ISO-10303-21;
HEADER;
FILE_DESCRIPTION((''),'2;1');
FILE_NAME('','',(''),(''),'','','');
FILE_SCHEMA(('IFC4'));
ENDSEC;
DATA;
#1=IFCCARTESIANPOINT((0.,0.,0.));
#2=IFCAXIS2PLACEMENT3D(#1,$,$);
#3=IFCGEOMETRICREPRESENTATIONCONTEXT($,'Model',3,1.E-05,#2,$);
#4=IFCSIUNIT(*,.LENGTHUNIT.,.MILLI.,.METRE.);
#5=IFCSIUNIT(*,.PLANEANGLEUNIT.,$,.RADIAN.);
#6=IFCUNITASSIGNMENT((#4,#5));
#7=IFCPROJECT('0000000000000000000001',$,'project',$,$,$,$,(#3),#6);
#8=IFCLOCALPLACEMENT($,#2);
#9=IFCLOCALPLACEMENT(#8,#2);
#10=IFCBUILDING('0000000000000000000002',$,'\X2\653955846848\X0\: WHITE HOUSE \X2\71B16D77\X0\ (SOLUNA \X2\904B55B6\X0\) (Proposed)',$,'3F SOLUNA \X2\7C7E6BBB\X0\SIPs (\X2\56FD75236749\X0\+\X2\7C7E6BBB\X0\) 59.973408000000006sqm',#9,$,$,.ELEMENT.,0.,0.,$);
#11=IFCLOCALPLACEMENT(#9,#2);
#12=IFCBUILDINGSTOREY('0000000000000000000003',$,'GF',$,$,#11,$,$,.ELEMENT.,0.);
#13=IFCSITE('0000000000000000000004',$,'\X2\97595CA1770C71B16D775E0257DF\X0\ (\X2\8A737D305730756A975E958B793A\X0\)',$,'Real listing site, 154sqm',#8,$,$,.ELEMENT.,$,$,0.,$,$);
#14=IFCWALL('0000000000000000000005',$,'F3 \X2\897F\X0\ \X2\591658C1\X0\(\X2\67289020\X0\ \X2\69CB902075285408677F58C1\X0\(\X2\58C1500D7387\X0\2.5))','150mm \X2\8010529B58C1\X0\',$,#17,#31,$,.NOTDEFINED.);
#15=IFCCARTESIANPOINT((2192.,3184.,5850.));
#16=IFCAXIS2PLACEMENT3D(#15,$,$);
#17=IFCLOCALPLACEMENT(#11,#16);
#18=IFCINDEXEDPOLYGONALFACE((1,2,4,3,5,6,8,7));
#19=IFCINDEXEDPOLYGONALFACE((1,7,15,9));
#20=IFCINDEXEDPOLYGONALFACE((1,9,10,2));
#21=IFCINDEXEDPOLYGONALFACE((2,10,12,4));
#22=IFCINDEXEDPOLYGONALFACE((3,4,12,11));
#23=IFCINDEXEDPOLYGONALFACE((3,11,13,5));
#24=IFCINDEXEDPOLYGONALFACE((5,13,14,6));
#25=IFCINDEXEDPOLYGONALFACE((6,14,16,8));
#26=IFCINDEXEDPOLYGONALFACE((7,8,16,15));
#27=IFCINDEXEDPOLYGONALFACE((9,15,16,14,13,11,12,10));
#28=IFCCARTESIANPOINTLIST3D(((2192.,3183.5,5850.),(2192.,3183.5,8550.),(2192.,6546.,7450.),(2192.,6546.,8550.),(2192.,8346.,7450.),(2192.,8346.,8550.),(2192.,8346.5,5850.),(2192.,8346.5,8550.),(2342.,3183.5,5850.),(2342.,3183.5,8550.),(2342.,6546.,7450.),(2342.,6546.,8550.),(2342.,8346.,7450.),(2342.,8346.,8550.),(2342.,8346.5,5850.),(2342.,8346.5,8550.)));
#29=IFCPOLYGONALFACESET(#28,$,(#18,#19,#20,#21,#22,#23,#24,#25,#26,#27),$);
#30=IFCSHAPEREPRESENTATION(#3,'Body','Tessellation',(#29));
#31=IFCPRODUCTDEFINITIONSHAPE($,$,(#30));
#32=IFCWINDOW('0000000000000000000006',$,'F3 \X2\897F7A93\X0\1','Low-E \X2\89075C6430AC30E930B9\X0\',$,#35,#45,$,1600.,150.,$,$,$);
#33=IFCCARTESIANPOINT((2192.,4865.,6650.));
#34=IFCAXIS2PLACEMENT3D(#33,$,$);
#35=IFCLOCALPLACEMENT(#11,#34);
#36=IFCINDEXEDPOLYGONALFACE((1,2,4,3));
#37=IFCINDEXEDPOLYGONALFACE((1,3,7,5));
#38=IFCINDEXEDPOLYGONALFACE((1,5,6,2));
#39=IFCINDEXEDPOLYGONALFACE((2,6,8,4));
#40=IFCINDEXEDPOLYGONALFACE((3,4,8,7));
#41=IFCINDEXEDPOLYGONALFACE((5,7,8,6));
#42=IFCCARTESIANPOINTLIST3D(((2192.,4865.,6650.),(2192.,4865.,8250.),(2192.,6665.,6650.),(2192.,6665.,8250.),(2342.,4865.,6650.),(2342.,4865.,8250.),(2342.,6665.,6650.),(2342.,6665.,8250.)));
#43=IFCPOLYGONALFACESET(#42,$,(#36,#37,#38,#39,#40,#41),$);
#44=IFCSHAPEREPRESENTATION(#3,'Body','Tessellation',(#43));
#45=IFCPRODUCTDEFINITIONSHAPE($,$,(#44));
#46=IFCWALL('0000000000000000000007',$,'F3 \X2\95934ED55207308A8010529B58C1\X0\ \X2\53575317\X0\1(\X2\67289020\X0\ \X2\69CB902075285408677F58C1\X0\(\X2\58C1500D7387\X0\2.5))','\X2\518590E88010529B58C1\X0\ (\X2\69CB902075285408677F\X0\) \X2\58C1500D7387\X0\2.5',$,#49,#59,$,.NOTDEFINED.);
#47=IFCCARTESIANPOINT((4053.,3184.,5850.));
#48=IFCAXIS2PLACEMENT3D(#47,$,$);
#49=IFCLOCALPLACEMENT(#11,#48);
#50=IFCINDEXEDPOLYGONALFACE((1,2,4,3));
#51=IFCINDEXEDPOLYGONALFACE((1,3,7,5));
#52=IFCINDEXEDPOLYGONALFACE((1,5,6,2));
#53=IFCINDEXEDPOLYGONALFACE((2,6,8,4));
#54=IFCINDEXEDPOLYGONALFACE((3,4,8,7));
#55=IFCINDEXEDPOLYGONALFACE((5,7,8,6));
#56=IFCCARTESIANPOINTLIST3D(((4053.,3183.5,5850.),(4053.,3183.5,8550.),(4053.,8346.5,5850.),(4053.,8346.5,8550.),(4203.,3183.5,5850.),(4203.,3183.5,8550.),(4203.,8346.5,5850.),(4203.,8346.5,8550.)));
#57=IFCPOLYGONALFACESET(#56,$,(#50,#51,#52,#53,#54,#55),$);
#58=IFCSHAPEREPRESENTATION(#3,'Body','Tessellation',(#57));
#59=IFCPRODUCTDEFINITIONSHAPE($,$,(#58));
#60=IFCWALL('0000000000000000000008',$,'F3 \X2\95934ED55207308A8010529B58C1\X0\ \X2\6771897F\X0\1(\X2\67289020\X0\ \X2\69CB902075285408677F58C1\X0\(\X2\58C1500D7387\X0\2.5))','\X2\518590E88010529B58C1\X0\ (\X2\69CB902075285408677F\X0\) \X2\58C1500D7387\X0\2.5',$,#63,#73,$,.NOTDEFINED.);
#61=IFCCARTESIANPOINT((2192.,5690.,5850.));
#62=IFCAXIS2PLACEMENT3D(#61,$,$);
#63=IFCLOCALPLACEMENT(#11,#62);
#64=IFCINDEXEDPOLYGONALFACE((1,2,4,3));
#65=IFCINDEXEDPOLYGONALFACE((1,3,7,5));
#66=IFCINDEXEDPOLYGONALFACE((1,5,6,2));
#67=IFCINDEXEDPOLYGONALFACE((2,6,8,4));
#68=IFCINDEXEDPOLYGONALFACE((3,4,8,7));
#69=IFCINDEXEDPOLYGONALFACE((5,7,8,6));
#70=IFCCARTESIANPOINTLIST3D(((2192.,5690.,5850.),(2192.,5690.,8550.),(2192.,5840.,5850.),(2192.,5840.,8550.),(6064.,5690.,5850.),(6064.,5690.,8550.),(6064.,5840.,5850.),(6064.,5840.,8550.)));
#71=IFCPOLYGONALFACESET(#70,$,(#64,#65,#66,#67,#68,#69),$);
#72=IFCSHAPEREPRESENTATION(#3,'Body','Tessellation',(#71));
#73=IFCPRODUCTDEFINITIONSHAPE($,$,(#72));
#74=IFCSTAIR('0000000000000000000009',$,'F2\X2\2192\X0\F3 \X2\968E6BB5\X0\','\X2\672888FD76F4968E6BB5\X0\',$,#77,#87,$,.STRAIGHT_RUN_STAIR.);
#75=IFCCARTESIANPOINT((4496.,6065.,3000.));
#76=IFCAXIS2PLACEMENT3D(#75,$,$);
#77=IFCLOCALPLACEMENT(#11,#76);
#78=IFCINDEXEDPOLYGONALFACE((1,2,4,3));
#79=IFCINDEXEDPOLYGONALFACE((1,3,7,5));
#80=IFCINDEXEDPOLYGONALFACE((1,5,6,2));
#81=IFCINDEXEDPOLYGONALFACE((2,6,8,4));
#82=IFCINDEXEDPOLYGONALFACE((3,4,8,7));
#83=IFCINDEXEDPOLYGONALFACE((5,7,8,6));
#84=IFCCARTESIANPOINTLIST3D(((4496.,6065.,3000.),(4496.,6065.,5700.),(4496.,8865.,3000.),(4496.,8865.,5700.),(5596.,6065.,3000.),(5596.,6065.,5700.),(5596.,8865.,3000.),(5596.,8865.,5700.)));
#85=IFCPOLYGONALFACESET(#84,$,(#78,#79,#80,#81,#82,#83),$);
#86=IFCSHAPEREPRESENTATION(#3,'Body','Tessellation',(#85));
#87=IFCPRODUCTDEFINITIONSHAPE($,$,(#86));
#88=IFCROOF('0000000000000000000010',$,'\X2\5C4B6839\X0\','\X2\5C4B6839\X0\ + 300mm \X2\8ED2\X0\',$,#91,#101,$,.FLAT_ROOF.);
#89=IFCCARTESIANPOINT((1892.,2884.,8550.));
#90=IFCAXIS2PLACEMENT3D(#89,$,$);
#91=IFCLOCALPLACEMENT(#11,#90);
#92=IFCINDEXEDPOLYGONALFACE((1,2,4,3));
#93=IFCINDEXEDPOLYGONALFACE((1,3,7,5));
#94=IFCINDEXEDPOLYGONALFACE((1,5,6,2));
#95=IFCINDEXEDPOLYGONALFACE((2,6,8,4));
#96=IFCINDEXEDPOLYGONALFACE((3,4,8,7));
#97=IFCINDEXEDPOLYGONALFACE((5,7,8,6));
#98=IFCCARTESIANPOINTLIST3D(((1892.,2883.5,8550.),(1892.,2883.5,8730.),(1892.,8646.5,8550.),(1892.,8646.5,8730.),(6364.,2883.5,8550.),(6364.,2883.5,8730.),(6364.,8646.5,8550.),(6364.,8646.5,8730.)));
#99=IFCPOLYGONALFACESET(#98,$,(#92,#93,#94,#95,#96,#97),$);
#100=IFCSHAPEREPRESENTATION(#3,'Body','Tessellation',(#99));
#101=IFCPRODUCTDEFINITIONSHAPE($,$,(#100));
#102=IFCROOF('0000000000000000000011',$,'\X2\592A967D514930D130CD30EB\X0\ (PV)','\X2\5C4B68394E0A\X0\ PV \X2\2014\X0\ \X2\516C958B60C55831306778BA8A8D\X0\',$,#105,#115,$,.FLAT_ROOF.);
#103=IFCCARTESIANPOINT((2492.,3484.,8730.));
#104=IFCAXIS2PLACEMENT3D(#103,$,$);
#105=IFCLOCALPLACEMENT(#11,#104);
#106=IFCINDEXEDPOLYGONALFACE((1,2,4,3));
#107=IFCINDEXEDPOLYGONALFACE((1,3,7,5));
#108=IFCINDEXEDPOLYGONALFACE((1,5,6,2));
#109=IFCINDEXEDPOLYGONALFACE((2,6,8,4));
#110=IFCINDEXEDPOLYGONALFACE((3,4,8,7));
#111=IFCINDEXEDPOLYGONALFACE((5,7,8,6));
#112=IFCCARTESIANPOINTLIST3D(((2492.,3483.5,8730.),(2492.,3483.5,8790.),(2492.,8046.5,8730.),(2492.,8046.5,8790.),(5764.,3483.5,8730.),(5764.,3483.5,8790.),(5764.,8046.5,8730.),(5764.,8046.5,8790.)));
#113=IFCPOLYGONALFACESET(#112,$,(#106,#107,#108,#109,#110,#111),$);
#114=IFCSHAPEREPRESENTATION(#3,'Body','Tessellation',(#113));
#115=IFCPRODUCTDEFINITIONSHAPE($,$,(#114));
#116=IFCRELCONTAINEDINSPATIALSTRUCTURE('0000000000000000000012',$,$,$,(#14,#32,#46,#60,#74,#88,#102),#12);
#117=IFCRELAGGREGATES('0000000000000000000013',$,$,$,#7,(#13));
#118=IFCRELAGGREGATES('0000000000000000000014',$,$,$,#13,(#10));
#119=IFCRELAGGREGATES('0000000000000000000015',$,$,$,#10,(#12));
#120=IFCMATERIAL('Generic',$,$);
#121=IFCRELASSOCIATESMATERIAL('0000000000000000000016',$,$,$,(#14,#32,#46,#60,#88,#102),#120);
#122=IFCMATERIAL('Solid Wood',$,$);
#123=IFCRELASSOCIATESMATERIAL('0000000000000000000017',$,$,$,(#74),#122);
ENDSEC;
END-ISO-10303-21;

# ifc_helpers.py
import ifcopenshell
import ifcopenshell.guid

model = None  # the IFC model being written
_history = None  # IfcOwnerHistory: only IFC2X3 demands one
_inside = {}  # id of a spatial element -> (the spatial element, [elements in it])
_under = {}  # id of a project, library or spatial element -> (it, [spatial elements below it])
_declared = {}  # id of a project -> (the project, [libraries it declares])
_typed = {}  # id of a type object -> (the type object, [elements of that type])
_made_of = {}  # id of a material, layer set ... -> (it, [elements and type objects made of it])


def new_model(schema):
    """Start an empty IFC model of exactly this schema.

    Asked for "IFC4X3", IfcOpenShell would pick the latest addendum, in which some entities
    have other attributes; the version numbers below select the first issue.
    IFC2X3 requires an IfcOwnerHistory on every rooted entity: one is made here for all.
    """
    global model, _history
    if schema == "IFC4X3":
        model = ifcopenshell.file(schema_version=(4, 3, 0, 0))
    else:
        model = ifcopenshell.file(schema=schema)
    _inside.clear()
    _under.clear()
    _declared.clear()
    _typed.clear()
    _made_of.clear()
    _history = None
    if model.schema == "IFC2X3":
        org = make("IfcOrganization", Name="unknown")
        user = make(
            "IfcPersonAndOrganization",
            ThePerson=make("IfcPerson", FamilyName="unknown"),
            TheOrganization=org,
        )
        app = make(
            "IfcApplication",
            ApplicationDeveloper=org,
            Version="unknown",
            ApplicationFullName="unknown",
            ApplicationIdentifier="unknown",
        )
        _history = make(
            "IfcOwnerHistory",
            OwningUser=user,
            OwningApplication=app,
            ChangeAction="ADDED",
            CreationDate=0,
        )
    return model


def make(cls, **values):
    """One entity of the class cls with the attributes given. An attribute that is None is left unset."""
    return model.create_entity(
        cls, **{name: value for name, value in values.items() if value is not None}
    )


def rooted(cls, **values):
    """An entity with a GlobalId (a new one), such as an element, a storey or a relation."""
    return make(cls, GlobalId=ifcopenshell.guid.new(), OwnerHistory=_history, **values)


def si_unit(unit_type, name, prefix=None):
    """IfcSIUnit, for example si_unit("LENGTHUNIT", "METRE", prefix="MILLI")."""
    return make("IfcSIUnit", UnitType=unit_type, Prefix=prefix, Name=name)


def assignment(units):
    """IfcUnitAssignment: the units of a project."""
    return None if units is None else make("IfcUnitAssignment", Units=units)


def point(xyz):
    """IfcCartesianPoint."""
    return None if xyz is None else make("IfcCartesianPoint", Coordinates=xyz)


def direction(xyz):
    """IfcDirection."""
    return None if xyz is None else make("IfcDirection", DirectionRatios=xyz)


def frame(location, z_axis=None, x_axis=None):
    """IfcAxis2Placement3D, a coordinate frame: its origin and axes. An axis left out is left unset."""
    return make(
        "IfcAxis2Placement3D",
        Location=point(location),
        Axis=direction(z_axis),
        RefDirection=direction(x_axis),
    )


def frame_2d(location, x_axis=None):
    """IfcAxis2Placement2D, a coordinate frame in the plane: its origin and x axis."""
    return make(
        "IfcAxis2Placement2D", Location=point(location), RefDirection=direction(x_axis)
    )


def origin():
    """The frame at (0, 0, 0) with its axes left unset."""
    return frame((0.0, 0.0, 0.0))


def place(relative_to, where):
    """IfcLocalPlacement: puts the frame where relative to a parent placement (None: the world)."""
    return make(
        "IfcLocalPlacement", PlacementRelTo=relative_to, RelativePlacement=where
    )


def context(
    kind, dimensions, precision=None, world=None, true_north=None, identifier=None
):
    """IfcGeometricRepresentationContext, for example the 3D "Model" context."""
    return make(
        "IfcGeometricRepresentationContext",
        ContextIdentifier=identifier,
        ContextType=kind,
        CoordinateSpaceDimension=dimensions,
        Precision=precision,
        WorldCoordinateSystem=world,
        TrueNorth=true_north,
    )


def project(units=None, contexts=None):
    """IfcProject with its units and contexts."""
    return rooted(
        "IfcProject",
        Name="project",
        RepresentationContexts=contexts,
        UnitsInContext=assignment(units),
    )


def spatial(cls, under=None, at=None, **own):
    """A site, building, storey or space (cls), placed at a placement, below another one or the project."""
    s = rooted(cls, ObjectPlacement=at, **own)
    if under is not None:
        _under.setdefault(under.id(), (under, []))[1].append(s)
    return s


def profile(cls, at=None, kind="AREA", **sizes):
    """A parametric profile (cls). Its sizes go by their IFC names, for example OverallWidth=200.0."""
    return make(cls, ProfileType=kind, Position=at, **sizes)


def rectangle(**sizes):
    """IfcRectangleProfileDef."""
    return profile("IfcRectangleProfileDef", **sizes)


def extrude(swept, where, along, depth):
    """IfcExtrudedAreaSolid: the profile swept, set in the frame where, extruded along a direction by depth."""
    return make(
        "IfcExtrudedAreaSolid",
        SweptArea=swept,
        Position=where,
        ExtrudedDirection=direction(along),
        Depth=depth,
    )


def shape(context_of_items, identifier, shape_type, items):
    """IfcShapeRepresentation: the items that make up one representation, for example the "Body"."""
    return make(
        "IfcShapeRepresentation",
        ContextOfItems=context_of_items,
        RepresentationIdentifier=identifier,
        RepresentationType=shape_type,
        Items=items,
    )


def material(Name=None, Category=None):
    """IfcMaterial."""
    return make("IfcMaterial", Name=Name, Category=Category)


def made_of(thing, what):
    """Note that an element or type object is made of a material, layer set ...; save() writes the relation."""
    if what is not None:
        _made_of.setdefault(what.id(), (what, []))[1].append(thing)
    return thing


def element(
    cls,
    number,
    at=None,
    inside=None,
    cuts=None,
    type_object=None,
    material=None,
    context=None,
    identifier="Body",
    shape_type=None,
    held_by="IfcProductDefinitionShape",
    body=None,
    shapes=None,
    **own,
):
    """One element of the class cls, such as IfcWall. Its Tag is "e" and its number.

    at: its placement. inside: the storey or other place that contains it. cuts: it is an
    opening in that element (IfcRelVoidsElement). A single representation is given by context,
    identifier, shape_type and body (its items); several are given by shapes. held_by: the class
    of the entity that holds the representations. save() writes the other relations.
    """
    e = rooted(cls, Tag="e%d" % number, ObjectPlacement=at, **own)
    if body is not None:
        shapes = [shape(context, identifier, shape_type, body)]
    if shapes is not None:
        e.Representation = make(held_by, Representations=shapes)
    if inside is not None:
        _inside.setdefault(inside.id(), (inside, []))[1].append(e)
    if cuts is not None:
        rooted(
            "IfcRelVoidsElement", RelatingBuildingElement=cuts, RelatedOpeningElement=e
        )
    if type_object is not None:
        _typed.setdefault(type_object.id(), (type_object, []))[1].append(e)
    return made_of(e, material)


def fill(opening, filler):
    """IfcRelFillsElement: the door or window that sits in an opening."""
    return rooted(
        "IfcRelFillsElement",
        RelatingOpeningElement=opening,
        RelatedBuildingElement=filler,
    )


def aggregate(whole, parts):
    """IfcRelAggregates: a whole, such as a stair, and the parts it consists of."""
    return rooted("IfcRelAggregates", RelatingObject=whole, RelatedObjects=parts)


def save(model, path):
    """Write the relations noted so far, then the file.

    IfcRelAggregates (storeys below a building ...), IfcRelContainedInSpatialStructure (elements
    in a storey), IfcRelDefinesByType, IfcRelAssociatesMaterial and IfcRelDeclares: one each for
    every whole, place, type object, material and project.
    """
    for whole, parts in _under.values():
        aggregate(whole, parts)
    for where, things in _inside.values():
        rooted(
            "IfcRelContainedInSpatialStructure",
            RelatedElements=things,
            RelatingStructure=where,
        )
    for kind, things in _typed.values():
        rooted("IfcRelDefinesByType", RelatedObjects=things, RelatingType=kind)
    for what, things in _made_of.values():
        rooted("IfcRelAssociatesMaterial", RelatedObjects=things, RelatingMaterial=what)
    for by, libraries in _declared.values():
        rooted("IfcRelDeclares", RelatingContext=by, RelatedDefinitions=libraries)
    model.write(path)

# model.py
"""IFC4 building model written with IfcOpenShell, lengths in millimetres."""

from ifc_helpers import new_model, si_unit, frame, frame_2d, origin, place, context, project, spatial, rectangle, extrude, material, element, fill, save


model = new_model("IFC4")

# Units and contexts
model_context = context("Model", 3, precision=1e-05, world=origin())
ifc_project = project(units=[si_unit("LENGTHUNIT", "METRE", prefix="MILLI"), si_unit("PLANEANGLEUNIT", "RADIAN")], contexts=[model_context])

# Site, building, storey
site_placement = place(None, origin())
site = spatial("IfcSite", under=ifc_project, at=site_placement, Name="静岡県熱海市域 (詳細地番非開示)", ObjectType="Real listing site, 154sqm", CompositionType="ELEMENT", RefElevation=0.0)
building_placement = place(site_placement, origin())
building = spatial("IfcBuilding", under=site, at=building_placement, Name="改善案: WHITE HOUSE 熱海 (SOLUNA 運営) (Proposed)", ObjectType="3F SOLUNA 籾殻SIPs (国産杉+籾殻) 59.973408000000006sqm", CompositionType="ELEMENT", ElevationOfRefHeight=0.0, ElevationOfTerrain=0.0)
storey_placement = place(building_placement, origin())
storey = spatial("IfcBuildingStorey", under=building, at=storey_placement, Name="GF", CompositionType="ELEMENT", Elevation=0.0)

# Shared definitions
ifc_material_1 = material(Name="Generic")

# Wall, opening, window
wall_1_placement = place(storey_placement, frame((2192.0, 3184.0, 5850.0)))
wall_1 = element("IfcWall", 1, at=wall_1_placement, inside=storey, material=ifc_material_1, Name="F3 西 外壁(木造 構造用合板壁(壁倍率2.5))", Description="150mm 耐力壁", PredefinedType="NOTDEFINED", context=model_context, shape_type="SweptSolid", body=[
    extrude(rectangle(XDim=150.0, YDim=5163.0, at=frame_2d((75.0, 2581.0))), frame((2192.0, 3184.0, 5850.0)), (0.0, 0.0, 1.0), 2700.0),
])
opening_1_placement = place(storey_placement, frame((2192.0, 4865.0, 6650.0)))
opening_1 = element("IfcOpeningElement", 2, at=opening_1_placement, cuts=wall_1, PredefinedType="NOTDEFINED", context=model_context, shape_type="SweptSolid", body=[
    extrude(rectangle(XDim=150.0, YDim=1800.0, at=frame_2d((75.0, 900.0))), frame((2192.0, 4865.0, 6650.0)), (0.0, 0.0, 1.0), 1600.0),
])
window_1_placement = place(storey_placement, frame((2192.0, 4865.0, 6650.0)))
window_1 = element("IfcWindow", 3, at=window_1_placement, inside=storey, material=ifc_material_1, Name="F3 西窓1", Description="Low-E 複層ガラス", OverallHeight=1600.0, OverallWidth=150.0, context=model_context, shape_type="SweptSolid", body=[
    extrude(rectangle(XDim=150.0, YDim=1800.0, at=frame_2d((75.0, 900.0))), frame((2192.0, 4865.0, 6650.0)), (0.0, 0.0, 1.0), 1600.0),
])
fill(opening_1, window_1)

# Walls
wall_2_placement = place(storey_placement, frame((4053.0, 3184.0, 5850.0)))
element("IfcWall", 4, at=wall_2_placement, inside=storey, material=ifc_material_1, Name="F3 間仕切り耐力壁 南北1(木造 構造用合板壁(壁倍率2.5))", Description="内部耐力壁 (構造用合板) 壁倍率2.5", PredefinedType="NOTDEFINED", context=model_context, shape_type="SweptSolid", body=[
    extrude(rectangle(XDim=150.0, YDim=5163.0, at=frame_2d((75.0, 2581.0))), frame((4053.0, 3184.0, 5850.0)), (0.0, 0.0, 1.0), 2700.0),
])
wall_3_placement = place(storey_placement, frame((2192.0, 5690.0, 5850.0)))
element("IfcWall", 5, at=wall_3_placement, inside=storey, material=ifc_material_1, Name="F3 間仕切り耐力壁 東西1(木造 構造用合板壁(壁倍率2.5))", Description="内部耐力壁 (構造用合板) 壁倍率2.5", PredefinedType="NOTDEFINED", context=model_context, shape_type="SweptSolid", body=[
    extrude(rectangle(XDim=3872.0, YDim=150.0, at=frame_2d((1936.0, 75.0))), frame((2192.0, 5690.0, 5850.0)), (0.0, 0.0, 1.0), 2700.0),
])

# Stair
ifc_material_2 = material(Name="Solid Wood")
stair_placement = place(storey_placement, frame((4496.0, 6065.0, 3000.0)))
element("IfcStair", 6, at=stair_placement, inside=storey, material=ifc_material_2, Name="F2→F3 階段", Description="木製直階段", PredefinedType="STRAIGHT_RUN_STAIR", context=model_context, shape_type="SweptSolid", body=[
    extrude(rectangle(XDim=1100.0, YDim=2800.0, at=frame_2d((550.0, 1400.0))), frame((4496.0, 6065.0, 3000.0)), (0.0, 0.0, 1.0), 2700.0),
])

# Roofs
roof_1_placement = place(storey_placement, frame((1892.0, 2884.0, 8550.0)))
element("IfcRoof", 7, at=roof_1_placement, inside=storey, material=ifc_material_1, Name="屋根", Description="屋根 + 300mm 軒", PredefinedType="FLAT_ROOF", context=model_context, shape_type="SweptSolid", body=[
    extrude(rectangle(XDim=4472.0, YDim=5763.0, at=frame_2d((2236.0, 2881.0))), frame((1892.0, 2884.0, 8550.0)), (0.0, 0.0, 1.0), 180.0),
])
roof_2_placement = place(storey_placement, frame((2492.0, 3484.0, 8730.0)))
element("IfcRoof", 8, at=roof_2_placement, inside=storey, material=ifc_material_1, Name="太陽光パネル (PV)", Description="屋根上 PV — 公開情報で確認", PredefinedType="FLAT_ROOF", context=model_context, shape_type="SweptSolid", body=[
    extrude(rectangle(XDim=3272.0, YDim=4563.0, at=frame_2d((1636.0, 2281.0))), frame((2492.0, 3484.0, 8730.0)), (0.0, 0.0, 1.0), 60.0),
])

save(model, "model.ifc")
